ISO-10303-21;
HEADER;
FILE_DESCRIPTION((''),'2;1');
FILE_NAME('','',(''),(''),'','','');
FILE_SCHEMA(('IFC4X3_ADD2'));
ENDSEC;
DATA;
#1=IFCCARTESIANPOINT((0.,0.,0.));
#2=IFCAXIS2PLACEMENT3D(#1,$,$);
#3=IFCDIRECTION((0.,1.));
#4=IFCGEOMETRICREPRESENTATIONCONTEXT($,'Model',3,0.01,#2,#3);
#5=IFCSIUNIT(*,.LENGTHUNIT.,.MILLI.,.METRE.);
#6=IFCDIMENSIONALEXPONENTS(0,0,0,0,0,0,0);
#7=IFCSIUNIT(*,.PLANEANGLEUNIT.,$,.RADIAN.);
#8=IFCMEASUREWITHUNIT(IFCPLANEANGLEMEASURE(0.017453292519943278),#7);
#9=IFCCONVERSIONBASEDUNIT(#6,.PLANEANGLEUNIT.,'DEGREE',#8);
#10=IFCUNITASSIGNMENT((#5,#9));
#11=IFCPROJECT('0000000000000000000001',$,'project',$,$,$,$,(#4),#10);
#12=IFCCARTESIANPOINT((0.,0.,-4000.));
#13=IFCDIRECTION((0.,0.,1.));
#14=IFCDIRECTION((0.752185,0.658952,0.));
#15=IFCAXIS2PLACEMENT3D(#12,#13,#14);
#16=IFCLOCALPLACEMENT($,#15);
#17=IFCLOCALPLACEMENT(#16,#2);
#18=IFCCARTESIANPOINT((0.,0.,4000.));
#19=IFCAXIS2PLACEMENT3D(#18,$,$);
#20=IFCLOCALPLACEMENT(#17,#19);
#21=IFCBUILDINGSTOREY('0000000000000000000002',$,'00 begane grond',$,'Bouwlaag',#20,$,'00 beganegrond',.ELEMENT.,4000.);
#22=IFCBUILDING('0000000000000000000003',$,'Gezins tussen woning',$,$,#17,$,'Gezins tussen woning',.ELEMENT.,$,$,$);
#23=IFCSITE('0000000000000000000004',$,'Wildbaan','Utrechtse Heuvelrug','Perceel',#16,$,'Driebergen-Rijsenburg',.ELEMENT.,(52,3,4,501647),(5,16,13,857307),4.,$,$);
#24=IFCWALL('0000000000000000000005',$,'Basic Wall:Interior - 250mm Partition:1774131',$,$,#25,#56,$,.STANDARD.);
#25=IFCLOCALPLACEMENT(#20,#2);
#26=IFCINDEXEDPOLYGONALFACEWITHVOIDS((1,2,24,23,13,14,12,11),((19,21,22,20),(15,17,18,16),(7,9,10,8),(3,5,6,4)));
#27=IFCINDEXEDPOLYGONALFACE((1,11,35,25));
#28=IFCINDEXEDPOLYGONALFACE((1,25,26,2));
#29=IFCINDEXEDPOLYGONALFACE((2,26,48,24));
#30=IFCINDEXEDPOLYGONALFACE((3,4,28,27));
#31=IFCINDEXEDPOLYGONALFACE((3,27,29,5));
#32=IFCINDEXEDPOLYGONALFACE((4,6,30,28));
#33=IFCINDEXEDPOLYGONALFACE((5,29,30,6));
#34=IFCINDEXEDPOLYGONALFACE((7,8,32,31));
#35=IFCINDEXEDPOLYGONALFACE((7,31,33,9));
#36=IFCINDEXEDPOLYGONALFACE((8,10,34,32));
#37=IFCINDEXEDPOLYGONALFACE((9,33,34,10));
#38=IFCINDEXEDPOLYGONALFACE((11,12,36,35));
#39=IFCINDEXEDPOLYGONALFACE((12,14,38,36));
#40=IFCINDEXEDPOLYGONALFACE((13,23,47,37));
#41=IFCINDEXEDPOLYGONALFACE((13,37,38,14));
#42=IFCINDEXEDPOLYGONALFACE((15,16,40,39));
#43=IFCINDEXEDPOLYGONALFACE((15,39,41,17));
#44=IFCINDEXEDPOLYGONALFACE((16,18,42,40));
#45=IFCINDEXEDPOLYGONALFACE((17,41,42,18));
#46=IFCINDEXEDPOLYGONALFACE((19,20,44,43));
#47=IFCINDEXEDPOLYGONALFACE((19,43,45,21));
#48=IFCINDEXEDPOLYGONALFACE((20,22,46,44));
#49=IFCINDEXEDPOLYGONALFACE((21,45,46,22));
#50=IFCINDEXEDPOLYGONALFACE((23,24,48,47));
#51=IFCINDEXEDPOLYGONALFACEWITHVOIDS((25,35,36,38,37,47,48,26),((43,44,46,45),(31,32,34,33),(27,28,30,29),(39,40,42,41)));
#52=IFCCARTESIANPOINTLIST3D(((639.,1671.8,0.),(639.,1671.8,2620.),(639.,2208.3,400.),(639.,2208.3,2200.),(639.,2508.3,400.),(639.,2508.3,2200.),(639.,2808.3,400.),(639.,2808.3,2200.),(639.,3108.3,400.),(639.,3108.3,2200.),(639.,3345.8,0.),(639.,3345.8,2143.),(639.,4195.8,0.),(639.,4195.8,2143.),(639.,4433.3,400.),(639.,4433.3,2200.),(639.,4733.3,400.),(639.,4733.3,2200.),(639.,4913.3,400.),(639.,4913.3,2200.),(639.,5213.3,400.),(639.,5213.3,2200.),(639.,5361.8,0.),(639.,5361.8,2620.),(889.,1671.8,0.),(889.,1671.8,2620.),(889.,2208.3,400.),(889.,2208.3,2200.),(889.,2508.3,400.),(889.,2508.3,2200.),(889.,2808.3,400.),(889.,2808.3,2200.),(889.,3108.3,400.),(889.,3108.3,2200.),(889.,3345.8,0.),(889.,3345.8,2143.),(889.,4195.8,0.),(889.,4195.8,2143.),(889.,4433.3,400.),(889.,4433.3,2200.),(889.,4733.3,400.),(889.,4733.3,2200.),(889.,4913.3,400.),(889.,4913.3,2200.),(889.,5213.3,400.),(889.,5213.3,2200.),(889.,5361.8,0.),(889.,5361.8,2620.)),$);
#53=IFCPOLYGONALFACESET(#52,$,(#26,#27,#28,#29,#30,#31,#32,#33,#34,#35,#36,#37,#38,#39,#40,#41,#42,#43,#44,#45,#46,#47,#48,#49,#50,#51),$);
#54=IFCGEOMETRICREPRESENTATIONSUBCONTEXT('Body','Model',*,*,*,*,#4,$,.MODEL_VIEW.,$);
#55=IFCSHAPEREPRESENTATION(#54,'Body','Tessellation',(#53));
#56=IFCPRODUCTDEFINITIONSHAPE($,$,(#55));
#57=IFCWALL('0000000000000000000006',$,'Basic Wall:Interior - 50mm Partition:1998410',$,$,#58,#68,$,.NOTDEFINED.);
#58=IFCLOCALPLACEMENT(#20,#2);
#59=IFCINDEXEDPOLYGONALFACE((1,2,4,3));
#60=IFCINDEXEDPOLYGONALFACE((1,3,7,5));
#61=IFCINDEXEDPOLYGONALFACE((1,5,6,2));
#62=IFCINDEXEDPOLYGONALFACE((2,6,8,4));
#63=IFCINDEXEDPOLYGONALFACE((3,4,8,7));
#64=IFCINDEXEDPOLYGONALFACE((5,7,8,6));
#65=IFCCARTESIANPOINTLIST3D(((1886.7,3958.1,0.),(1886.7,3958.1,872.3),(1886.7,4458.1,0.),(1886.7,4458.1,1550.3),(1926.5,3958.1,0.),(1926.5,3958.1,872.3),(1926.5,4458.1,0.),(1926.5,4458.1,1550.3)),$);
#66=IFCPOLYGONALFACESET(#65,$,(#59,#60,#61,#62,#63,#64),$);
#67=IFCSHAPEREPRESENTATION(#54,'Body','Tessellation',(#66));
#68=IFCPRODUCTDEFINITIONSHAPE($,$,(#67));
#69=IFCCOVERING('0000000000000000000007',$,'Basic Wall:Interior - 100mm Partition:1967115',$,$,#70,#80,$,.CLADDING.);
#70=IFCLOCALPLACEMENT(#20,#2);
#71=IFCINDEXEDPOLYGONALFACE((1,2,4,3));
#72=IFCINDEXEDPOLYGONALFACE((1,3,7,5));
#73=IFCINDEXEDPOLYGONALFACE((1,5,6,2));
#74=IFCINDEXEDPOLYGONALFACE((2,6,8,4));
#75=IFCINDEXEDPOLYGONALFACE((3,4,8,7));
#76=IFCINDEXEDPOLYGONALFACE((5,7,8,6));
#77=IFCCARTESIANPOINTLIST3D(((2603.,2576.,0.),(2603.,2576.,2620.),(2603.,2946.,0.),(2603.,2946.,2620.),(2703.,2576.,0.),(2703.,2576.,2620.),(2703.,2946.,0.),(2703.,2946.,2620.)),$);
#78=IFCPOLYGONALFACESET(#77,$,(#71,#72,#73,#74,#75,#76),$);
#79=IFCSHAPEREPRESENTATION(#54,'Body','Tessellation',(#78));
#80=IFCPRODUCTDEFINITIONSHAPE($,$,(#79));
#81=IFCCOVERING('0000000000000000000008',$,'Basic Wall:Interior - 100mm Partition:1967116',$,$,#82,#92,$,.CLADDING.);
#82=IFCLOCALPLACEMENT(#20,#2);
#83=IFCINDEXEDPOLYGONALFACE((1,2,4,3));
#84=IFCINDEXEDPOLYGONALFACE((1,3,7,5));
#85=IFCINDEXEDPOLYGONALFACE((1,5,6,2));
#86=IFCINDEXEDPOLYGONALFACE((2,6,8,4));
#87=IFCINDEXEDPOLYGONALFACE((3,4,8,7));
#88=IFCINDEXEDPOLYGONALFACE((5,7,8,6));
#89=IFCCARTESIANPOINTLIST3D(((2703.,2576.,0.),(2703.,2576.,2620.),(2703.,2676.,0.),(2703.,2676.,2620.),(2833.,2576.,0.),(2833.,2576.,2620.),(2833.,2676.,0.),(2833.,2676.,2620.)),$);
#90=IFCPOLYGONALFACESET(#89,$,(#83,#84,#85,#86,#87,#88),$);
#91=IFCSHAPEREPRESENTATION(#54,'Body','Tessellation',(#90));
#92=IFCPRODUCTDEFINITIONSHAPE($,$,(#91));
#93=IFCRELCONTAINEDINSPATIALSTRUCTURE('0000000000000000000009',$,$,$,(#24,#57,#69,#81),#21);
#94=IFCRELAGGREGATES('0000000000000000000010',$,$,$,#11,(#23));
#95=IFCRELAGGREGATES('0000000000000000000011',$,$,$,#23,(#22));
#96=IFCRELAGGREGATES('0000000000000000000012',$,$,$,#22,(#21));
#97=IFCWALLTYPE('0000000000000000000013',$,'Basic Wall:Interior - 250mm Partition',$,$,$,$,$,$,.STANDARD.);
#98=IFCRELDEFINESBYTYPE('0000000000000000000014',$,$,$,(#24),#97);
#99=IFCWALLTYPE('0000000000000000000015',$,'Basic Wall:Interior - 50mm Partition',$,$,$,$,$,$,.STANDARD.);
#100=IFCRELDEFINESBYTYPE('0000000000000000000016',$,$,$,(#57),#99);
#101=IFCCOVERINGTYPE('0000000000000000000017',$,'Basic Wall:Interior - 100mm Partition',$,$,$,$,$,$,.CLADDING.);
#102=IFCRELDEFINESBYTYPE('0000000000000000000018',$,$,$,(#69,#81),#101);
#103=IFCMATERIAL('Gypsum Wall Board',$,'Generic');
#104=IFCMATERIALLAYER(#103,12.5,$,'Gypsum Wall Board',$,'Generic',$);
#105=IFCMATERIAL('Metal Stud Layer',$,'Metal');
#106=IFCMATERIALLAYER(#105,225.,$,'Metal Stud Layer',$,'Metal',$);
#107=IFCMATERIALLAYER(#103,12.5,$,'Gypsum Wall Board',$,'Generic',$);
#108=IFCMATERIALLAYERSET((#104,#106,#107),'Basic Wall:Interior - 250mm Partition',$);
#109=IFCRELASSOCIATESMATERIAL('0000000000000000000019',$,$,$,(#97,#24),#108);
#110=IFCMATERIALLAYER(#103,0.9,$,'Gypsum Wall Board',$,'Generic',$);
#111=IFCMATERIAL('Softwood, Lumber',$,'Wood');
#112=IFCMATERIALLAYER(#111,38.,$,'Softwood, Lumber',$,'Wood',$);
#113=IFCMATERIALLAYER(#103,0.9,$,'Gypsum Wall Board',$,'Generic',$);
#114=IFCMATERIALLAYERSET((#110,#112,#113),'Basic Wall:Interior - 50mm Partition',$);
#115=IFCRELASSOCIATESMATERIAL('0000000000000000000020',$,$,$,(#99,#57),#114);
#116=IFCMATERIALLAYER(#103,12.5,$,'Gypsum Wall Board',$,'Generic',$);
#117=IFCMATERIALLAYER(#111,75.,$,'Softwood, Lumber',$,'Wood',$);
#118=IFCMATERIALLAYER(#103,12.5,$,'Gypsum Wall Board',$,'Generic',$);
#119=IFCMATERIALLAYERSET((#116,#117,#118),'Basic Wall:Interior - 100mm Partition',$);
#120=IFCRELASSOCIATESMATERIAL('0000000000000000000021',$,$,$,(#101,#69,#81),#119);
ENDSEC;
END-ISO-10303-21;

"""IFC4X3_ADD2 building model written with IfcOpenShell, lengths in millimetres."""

from ifc_helpers import new_model, entity, si_unit, converted_unit, direction, frame, frame_2d, origin, place, context, subcontext, project, spatial, polyline, rectangle, extrude, clip, halfspace, bounded_halfspace, material, layer, layer_set, layer_usage, type_object, element, save


model = new_model("IFC4X3_ADD2")

# Units and contexts
model_context = context("Model", 3, precision=0.01, world=origin(), true_north=direction((0.0, 1.0)))
body_context = subcontext(model_context, "Body", "Model", "MODEL_VIEW")
ifc_project = project(units=[si_unit("LENGTHUNIT", "METRE", prefix="MILLI"), converted_unit("PLANEANGLEUNIT", "DEGREE", entity("IfcPlaneAngleMeasure", 0.017453292519943278), si_unit("PLANEANGLEUNIT", "RADIAN"), dimensions=[0, 0, 0, 0, 0, 0, 0])], contexts=[model_context])

# Site, building, storey
site_placement = place(None, frame((0.0, 0.0, -4000.0), z_axis=(0.0, 0.0, 1.0), x_axis=(0.752185, 0.658952, 0.0)))
site = spatial("IfcSite", under=ifc_project, at=site_placement, Name="Wildbaan", Description="Utrechtse Heuvelrug", ObjectType="Perceel", LongName="Driebergen-Rijsenburg", CompositionType="ELEMENT", RefLatitude=(52, 3, 4, 501647), RefLongitude=(5, 16, 13, 857307), RefElevation=4.0)
building_placement = place(site_placement, origin())
building = spatial("IfcBuilding", under=site, at=building_placement, Name="Gezins tussen woning", LongName="Gezins tussen woning", CompositionType="ELEMENT")
storey_placement = place(building_placement, frame((0.0, 0.0, 4000.0)))
storey = spatial("IfcBuildingStorey", under=building, at=storey_placement, Name="00 begane grond", ObjectType="Bouwlaag", LongName="00 beganegrond", CompositionType="ELEMENT", Elevation=4000.0)

# Shared definitions
ifc_material_1 = material(Name="Gypsum Wall Board", Category="Generic")
ifc_layer_1 = layer(ifc_material_1, 12.5, Name="Gypsum Wall Board", Category="Generic")
ifc_material_2 = material(Name="Softwood, Lumber", Category="Wood")
ifc_layer_2 = layer(ifc_material_2, 75.0, Name="Softwood, Lumber", Category="Wood")
ifc_layer_3 = layer(ifc_material_1, 12.5, Name="Gypsum Wall Board", Category="Generic")
ifc_layer_set_1 = layer_set([ifc_layer_1, ifc_layer_2, ifc_layer_3], Name="Basic Wall:Interior - 100mm Partition")

# Wall, openings
ifc_layer_4 = layer(ifc_material_1, 12.5, Name="Gypsum Wall Board", Category="Generic")
ifc_material_3 = material(Name="Metal Stud Layer", Category="Metal")
ifc_layer_5 = layer(ifc_material_3, 225.0, Name="Metal Stud Layer", Category="Metal")
ifc_layer_6 = layer(ifc_material_1, 12.5, Name="Gypsum Wall Board", Category="Generic")
ifc_layer_set_2 = layer_set([ifc_layer_4, ifc_layer_5, ifc_layer_6], Name="Basic Wall:Interior - 250mm Partition")
wall_type_1 = type_object("IfcWallType", Name="Basic Wall:Interior - 250mm Partition", PredefinedType="STANDARD", material=ifc_layer_set_2)
wall_1_placement = place(storey_placement, frame((764.0, 1671.8, 0.0), z_axis=(0.0, 0.0, 1.0), x_axis=(0.0, 1.0, 0.0)))
wall_1 = element("IfcWall", 1, at=wall_1_placement, inside=storey, type_object=wall_type_1, material=ifc_layer_set_2, Name="Basic Wall:Interior - 250mm Partition:1774131", PredefinedType="STANDARD", context=body_context, shape_type="Clipping", body=[
    clip(clip(extrude(rectangle(XDim=250.0, YDim=3690.0, at=frame_2d((1845.0, 0.0), x_axis=(0.0, 1.0))), origin(), (0.0, 0.0, 1.0), 2620.0), bounded_halfspace(frame((0.0, -125.0, 2620.0), z_axis=(0.0, 0.0, -1.0), x_axis=(-1.0, 0.0, 0.0)), True, frame((0.0, -125.0, 2620.0)), polyline([(0.0, 0.0), (3690.0, 0.0), (3690.0, 106.0), (0.0, 106.0), (0.0, 0.0)]))), bounded_halfspace(frame((3690.0, -19.0, 2620.0), z_axis=(0.0, 0.0, -1.0), x_axis=(-1.0, 0.0, 0.0)), True, frame((3690.0, -19.0, 2620.0)), polyline([(0.0, 0.0), (0.0, 144.0), (-3690.0, 144.0), (-3690.0, 0.0), (0.0, 0.0)]))),
])
opening_1_placement = place(wall_1_placement, frame((-1671.8, 764.0, -2.0), z_axis=(0.0, 0.0, 1.0), x_axis=(0.0, -1.0, 0.0)))
element("IfcOpeningElement", 2, at=opening_1_placement, cuts=wall_1, PredefinedType="OPENING", context=body_context, shape_type="SweptSolid", body=[
    extrude(rectangle(XDim=2145.0, YDim=850.0, at=frame_2d((0.0, 0.0), x_axis=(1.0, 0.0))), frame((889.0, 3770.8, 1072.5), z_axis=(-1.0, 0.0, 0.0), x_axis=(0.0, 0.0, -1.0)), (0.0, 0.0, 1.0), 250.0),
])
opening_2_placement = place(wall_1_placement, frame((-1671.8, 764.0, 400.0), z_axis=(0.0, 0.0, 1.0), x_axis=(0.0, -1.0, 0.0)))
element("IfcOpeningElement", 3, at=opening_2_placement, cuts=wall_1, PredefinedType="OPENING", context=body_context, shape_type="SweptSolid", body=[
    extrude(rectangle(XDim=1800.0, YDim=300.0, at=frame_2d((0.0, 0.0), x_axis=(0.0, 1.0))), frame((889.0, 5063.3, 900.0), z_axis=(-1.0, 0.0, 0.0), x_axis=(0.0, 1.0, 0.0)), (0.0, 0.0, 1.0), 250.0),
])
opening_3_placement = place(wall_1_placement, frame((-1671.8, 764.0, 400.0), z_axis=(0.0, 0.0, 1.0), x_axis=(0.0, -1.0, 0.0)))
element("IfcOpeningElement", 4, at=opening_3_placement, cuts=wall_1, PredefinedType="OPENING", context=body_context, shape_type="SweptSolid", body=[
    extrude(rectangle(XDim=1800.0, YDim=300.0, at=frame_2d((0.0, 0.0), x_axis=(0.0, 1.0))), frame((889.0, 4583.3, 900.0), z_axis=(-1.0, 0.0, 0.0), x_axis=(0.0, 1.0, 0.0)), (0.0, 0.0, 1.0), 250.0),
])
opening_4_placement = place(wall_1_placement, frame((-1671.8, 764.0, 400.0), z_axis=(0.0, 0.0, 1.0), x_axis=(0.0, -1.0, 0.0)))
element("IfcOpeningElement", 5, at=opening_4_placement, cuts=wall_1, PredefinedType="OPENING", context=body_context, shape_type="SweptSolid", body=[
    extrude(rectangle(XDim=1800.0, YDim=300.0, at=frame_2d((0.0, 0.0), x_axis=(1.0, 0.0))), frame((889.0, 2358.3, 900.0), z_axis=(-1.0, 0.0, 0.0), x_axis=(0.0, 0.0, -1.0)), (0.0, 0.0, 1.0), 250.0),
])
opening_5_placement = place(wall_1_placement, frame((-1671.8, 764.0, 400.0), z_axis=(0.0, 0.0, 1.0), x_axis=(0.0, -1.0, 0.0)))
element("IfcOpeningElement", 6, at=opening_5_placement, cuts=wall_1, PredefinedType="OPENING", context=body_context, shape_type="SweptSolid", body=[
    extrude(rectangle(XDim=1800.0, YDim=300.0, at=frame_2d((0.0, 0.0), x_axis=(1.0, 0.0))), frame((889.0, 2958.3, 900.0), z_axis=(-1.0, 0.0, 0.0), x_axis=(0.0, 0.0, -1.0)), (0.0, 0.0, 1.0), 250.0),
])

# Wall
ifc_layer_7 = layer(ifc_material_1, 0.9, Name="Gypsum Wall Board", Category="Generic")
ifc_layer_8 = layer(ifc_material_2, 38.0, Name="Softwood, Lumber", Category="Wood")
ifc_layer_9 = layer(ifc_material_1, 0.9, Name="Gypsum Wall Board", Category="Generic")
ifc_layer_set_3 = layer_set([ifc_layer_7, ifc_layer_8, ifc_layer_9], Name="Basic Wall:Interior - 50mm Partition")
wall_type_2 = type_object("IfcWallType", Name="Basic Wall:Interior - 50mm Partition", PredefinedType="STANDARD", material=ifc_layer_set_3)
wall_2_placement = place(storey_placement, frame((1906.6, 3958.1, 0.0), z_axis=(0.0, 0.0, 1.0), x_axis=(0.0, 1.0, 0.0)))
element("IfcWall", 7, at=wall_2_placement, inside=storey, type_object=wall_type_2, material=ifc_layer_set_3, Name="Basic Wall:Interior - 50mm Partition:1998410", PredefinedType="NOTDEFINED", context=body_context, shape_type="Clipping", body=[
    clip(extrude(rectangle(XDim=500.0, YDim=39.8, at=frame_2d((250.0, 0.0), x_axis=(-1.0, 0.0))), origin(), (0.0, 0.0, 1.0), 1550.3), halfspace(frame((0.0, -19.9, 872.3), z_axis=(-0.804819, 0.0, 0.593521), x_axis=(0.0, 1.0, 0.0)), False)),
])

# Coverings
ifc_layer_usage_1 = layer_usage(ifc_layer_set_1, "AXIS2", "NEGATIVE", 50.0)
covering_type_1 = type_object("IfcCoveringType", Name="Basic Wall:Interior - 100mm Partition", PredefinedType="CLADDING", material=ifc_layer_set_1)
covering_1_placement = place(storey_placement, frame((2653.0, 2946.0, 0.0), z_axis=(0.0, 0.0, 1.0), x_axis=(0.0, -1.0, 0.0)))
element("IfcCovering", 8, at=covering_1_placement, inside=storey, type_object=covering_type_1, material=ifc_layer_usage_1, Name="Basic Wall:Interior - 100mm Partition:1967115", PredefinedType="CLADDING", context=body_context, shape_type="SweptSolid", body=[
    extrude(rectangle(XDim=370.0, YDim=100.0, at=frame_2d((185.0, 0.0), x_axis=(-1.0, 0.0))), origin(), (0.0, 0.0, 1.0), 2620.0),
])
ifc_layer_usage_2 = layer_usage(ifc_layer_set_1, "AXIS2", "NEGATIVE", 50.0)
covering_2_placement = place(storey_placement, frame((2703.0, 2626.0, 0.0)))
element("IfcCovering", 9, at=covering_2_placement, inside=storey, type_object=covering_type_1, material=ifc_layer_usage_2, Name="Basic Wall:Interior - 100mm Partition:1967116", PredefinedType="CLADDING", context=body_context, shape_type="SweptSolid", body=[
    extrude(rectangle(XDim=130.0, YDim=100.0, at=frame_2d((65.0, 0.0), x_axis=(-1.0, 0.0))), origin(), (0.0, 0.0, 1.0), 2620.0),
])

save(model, "model.ifc")
